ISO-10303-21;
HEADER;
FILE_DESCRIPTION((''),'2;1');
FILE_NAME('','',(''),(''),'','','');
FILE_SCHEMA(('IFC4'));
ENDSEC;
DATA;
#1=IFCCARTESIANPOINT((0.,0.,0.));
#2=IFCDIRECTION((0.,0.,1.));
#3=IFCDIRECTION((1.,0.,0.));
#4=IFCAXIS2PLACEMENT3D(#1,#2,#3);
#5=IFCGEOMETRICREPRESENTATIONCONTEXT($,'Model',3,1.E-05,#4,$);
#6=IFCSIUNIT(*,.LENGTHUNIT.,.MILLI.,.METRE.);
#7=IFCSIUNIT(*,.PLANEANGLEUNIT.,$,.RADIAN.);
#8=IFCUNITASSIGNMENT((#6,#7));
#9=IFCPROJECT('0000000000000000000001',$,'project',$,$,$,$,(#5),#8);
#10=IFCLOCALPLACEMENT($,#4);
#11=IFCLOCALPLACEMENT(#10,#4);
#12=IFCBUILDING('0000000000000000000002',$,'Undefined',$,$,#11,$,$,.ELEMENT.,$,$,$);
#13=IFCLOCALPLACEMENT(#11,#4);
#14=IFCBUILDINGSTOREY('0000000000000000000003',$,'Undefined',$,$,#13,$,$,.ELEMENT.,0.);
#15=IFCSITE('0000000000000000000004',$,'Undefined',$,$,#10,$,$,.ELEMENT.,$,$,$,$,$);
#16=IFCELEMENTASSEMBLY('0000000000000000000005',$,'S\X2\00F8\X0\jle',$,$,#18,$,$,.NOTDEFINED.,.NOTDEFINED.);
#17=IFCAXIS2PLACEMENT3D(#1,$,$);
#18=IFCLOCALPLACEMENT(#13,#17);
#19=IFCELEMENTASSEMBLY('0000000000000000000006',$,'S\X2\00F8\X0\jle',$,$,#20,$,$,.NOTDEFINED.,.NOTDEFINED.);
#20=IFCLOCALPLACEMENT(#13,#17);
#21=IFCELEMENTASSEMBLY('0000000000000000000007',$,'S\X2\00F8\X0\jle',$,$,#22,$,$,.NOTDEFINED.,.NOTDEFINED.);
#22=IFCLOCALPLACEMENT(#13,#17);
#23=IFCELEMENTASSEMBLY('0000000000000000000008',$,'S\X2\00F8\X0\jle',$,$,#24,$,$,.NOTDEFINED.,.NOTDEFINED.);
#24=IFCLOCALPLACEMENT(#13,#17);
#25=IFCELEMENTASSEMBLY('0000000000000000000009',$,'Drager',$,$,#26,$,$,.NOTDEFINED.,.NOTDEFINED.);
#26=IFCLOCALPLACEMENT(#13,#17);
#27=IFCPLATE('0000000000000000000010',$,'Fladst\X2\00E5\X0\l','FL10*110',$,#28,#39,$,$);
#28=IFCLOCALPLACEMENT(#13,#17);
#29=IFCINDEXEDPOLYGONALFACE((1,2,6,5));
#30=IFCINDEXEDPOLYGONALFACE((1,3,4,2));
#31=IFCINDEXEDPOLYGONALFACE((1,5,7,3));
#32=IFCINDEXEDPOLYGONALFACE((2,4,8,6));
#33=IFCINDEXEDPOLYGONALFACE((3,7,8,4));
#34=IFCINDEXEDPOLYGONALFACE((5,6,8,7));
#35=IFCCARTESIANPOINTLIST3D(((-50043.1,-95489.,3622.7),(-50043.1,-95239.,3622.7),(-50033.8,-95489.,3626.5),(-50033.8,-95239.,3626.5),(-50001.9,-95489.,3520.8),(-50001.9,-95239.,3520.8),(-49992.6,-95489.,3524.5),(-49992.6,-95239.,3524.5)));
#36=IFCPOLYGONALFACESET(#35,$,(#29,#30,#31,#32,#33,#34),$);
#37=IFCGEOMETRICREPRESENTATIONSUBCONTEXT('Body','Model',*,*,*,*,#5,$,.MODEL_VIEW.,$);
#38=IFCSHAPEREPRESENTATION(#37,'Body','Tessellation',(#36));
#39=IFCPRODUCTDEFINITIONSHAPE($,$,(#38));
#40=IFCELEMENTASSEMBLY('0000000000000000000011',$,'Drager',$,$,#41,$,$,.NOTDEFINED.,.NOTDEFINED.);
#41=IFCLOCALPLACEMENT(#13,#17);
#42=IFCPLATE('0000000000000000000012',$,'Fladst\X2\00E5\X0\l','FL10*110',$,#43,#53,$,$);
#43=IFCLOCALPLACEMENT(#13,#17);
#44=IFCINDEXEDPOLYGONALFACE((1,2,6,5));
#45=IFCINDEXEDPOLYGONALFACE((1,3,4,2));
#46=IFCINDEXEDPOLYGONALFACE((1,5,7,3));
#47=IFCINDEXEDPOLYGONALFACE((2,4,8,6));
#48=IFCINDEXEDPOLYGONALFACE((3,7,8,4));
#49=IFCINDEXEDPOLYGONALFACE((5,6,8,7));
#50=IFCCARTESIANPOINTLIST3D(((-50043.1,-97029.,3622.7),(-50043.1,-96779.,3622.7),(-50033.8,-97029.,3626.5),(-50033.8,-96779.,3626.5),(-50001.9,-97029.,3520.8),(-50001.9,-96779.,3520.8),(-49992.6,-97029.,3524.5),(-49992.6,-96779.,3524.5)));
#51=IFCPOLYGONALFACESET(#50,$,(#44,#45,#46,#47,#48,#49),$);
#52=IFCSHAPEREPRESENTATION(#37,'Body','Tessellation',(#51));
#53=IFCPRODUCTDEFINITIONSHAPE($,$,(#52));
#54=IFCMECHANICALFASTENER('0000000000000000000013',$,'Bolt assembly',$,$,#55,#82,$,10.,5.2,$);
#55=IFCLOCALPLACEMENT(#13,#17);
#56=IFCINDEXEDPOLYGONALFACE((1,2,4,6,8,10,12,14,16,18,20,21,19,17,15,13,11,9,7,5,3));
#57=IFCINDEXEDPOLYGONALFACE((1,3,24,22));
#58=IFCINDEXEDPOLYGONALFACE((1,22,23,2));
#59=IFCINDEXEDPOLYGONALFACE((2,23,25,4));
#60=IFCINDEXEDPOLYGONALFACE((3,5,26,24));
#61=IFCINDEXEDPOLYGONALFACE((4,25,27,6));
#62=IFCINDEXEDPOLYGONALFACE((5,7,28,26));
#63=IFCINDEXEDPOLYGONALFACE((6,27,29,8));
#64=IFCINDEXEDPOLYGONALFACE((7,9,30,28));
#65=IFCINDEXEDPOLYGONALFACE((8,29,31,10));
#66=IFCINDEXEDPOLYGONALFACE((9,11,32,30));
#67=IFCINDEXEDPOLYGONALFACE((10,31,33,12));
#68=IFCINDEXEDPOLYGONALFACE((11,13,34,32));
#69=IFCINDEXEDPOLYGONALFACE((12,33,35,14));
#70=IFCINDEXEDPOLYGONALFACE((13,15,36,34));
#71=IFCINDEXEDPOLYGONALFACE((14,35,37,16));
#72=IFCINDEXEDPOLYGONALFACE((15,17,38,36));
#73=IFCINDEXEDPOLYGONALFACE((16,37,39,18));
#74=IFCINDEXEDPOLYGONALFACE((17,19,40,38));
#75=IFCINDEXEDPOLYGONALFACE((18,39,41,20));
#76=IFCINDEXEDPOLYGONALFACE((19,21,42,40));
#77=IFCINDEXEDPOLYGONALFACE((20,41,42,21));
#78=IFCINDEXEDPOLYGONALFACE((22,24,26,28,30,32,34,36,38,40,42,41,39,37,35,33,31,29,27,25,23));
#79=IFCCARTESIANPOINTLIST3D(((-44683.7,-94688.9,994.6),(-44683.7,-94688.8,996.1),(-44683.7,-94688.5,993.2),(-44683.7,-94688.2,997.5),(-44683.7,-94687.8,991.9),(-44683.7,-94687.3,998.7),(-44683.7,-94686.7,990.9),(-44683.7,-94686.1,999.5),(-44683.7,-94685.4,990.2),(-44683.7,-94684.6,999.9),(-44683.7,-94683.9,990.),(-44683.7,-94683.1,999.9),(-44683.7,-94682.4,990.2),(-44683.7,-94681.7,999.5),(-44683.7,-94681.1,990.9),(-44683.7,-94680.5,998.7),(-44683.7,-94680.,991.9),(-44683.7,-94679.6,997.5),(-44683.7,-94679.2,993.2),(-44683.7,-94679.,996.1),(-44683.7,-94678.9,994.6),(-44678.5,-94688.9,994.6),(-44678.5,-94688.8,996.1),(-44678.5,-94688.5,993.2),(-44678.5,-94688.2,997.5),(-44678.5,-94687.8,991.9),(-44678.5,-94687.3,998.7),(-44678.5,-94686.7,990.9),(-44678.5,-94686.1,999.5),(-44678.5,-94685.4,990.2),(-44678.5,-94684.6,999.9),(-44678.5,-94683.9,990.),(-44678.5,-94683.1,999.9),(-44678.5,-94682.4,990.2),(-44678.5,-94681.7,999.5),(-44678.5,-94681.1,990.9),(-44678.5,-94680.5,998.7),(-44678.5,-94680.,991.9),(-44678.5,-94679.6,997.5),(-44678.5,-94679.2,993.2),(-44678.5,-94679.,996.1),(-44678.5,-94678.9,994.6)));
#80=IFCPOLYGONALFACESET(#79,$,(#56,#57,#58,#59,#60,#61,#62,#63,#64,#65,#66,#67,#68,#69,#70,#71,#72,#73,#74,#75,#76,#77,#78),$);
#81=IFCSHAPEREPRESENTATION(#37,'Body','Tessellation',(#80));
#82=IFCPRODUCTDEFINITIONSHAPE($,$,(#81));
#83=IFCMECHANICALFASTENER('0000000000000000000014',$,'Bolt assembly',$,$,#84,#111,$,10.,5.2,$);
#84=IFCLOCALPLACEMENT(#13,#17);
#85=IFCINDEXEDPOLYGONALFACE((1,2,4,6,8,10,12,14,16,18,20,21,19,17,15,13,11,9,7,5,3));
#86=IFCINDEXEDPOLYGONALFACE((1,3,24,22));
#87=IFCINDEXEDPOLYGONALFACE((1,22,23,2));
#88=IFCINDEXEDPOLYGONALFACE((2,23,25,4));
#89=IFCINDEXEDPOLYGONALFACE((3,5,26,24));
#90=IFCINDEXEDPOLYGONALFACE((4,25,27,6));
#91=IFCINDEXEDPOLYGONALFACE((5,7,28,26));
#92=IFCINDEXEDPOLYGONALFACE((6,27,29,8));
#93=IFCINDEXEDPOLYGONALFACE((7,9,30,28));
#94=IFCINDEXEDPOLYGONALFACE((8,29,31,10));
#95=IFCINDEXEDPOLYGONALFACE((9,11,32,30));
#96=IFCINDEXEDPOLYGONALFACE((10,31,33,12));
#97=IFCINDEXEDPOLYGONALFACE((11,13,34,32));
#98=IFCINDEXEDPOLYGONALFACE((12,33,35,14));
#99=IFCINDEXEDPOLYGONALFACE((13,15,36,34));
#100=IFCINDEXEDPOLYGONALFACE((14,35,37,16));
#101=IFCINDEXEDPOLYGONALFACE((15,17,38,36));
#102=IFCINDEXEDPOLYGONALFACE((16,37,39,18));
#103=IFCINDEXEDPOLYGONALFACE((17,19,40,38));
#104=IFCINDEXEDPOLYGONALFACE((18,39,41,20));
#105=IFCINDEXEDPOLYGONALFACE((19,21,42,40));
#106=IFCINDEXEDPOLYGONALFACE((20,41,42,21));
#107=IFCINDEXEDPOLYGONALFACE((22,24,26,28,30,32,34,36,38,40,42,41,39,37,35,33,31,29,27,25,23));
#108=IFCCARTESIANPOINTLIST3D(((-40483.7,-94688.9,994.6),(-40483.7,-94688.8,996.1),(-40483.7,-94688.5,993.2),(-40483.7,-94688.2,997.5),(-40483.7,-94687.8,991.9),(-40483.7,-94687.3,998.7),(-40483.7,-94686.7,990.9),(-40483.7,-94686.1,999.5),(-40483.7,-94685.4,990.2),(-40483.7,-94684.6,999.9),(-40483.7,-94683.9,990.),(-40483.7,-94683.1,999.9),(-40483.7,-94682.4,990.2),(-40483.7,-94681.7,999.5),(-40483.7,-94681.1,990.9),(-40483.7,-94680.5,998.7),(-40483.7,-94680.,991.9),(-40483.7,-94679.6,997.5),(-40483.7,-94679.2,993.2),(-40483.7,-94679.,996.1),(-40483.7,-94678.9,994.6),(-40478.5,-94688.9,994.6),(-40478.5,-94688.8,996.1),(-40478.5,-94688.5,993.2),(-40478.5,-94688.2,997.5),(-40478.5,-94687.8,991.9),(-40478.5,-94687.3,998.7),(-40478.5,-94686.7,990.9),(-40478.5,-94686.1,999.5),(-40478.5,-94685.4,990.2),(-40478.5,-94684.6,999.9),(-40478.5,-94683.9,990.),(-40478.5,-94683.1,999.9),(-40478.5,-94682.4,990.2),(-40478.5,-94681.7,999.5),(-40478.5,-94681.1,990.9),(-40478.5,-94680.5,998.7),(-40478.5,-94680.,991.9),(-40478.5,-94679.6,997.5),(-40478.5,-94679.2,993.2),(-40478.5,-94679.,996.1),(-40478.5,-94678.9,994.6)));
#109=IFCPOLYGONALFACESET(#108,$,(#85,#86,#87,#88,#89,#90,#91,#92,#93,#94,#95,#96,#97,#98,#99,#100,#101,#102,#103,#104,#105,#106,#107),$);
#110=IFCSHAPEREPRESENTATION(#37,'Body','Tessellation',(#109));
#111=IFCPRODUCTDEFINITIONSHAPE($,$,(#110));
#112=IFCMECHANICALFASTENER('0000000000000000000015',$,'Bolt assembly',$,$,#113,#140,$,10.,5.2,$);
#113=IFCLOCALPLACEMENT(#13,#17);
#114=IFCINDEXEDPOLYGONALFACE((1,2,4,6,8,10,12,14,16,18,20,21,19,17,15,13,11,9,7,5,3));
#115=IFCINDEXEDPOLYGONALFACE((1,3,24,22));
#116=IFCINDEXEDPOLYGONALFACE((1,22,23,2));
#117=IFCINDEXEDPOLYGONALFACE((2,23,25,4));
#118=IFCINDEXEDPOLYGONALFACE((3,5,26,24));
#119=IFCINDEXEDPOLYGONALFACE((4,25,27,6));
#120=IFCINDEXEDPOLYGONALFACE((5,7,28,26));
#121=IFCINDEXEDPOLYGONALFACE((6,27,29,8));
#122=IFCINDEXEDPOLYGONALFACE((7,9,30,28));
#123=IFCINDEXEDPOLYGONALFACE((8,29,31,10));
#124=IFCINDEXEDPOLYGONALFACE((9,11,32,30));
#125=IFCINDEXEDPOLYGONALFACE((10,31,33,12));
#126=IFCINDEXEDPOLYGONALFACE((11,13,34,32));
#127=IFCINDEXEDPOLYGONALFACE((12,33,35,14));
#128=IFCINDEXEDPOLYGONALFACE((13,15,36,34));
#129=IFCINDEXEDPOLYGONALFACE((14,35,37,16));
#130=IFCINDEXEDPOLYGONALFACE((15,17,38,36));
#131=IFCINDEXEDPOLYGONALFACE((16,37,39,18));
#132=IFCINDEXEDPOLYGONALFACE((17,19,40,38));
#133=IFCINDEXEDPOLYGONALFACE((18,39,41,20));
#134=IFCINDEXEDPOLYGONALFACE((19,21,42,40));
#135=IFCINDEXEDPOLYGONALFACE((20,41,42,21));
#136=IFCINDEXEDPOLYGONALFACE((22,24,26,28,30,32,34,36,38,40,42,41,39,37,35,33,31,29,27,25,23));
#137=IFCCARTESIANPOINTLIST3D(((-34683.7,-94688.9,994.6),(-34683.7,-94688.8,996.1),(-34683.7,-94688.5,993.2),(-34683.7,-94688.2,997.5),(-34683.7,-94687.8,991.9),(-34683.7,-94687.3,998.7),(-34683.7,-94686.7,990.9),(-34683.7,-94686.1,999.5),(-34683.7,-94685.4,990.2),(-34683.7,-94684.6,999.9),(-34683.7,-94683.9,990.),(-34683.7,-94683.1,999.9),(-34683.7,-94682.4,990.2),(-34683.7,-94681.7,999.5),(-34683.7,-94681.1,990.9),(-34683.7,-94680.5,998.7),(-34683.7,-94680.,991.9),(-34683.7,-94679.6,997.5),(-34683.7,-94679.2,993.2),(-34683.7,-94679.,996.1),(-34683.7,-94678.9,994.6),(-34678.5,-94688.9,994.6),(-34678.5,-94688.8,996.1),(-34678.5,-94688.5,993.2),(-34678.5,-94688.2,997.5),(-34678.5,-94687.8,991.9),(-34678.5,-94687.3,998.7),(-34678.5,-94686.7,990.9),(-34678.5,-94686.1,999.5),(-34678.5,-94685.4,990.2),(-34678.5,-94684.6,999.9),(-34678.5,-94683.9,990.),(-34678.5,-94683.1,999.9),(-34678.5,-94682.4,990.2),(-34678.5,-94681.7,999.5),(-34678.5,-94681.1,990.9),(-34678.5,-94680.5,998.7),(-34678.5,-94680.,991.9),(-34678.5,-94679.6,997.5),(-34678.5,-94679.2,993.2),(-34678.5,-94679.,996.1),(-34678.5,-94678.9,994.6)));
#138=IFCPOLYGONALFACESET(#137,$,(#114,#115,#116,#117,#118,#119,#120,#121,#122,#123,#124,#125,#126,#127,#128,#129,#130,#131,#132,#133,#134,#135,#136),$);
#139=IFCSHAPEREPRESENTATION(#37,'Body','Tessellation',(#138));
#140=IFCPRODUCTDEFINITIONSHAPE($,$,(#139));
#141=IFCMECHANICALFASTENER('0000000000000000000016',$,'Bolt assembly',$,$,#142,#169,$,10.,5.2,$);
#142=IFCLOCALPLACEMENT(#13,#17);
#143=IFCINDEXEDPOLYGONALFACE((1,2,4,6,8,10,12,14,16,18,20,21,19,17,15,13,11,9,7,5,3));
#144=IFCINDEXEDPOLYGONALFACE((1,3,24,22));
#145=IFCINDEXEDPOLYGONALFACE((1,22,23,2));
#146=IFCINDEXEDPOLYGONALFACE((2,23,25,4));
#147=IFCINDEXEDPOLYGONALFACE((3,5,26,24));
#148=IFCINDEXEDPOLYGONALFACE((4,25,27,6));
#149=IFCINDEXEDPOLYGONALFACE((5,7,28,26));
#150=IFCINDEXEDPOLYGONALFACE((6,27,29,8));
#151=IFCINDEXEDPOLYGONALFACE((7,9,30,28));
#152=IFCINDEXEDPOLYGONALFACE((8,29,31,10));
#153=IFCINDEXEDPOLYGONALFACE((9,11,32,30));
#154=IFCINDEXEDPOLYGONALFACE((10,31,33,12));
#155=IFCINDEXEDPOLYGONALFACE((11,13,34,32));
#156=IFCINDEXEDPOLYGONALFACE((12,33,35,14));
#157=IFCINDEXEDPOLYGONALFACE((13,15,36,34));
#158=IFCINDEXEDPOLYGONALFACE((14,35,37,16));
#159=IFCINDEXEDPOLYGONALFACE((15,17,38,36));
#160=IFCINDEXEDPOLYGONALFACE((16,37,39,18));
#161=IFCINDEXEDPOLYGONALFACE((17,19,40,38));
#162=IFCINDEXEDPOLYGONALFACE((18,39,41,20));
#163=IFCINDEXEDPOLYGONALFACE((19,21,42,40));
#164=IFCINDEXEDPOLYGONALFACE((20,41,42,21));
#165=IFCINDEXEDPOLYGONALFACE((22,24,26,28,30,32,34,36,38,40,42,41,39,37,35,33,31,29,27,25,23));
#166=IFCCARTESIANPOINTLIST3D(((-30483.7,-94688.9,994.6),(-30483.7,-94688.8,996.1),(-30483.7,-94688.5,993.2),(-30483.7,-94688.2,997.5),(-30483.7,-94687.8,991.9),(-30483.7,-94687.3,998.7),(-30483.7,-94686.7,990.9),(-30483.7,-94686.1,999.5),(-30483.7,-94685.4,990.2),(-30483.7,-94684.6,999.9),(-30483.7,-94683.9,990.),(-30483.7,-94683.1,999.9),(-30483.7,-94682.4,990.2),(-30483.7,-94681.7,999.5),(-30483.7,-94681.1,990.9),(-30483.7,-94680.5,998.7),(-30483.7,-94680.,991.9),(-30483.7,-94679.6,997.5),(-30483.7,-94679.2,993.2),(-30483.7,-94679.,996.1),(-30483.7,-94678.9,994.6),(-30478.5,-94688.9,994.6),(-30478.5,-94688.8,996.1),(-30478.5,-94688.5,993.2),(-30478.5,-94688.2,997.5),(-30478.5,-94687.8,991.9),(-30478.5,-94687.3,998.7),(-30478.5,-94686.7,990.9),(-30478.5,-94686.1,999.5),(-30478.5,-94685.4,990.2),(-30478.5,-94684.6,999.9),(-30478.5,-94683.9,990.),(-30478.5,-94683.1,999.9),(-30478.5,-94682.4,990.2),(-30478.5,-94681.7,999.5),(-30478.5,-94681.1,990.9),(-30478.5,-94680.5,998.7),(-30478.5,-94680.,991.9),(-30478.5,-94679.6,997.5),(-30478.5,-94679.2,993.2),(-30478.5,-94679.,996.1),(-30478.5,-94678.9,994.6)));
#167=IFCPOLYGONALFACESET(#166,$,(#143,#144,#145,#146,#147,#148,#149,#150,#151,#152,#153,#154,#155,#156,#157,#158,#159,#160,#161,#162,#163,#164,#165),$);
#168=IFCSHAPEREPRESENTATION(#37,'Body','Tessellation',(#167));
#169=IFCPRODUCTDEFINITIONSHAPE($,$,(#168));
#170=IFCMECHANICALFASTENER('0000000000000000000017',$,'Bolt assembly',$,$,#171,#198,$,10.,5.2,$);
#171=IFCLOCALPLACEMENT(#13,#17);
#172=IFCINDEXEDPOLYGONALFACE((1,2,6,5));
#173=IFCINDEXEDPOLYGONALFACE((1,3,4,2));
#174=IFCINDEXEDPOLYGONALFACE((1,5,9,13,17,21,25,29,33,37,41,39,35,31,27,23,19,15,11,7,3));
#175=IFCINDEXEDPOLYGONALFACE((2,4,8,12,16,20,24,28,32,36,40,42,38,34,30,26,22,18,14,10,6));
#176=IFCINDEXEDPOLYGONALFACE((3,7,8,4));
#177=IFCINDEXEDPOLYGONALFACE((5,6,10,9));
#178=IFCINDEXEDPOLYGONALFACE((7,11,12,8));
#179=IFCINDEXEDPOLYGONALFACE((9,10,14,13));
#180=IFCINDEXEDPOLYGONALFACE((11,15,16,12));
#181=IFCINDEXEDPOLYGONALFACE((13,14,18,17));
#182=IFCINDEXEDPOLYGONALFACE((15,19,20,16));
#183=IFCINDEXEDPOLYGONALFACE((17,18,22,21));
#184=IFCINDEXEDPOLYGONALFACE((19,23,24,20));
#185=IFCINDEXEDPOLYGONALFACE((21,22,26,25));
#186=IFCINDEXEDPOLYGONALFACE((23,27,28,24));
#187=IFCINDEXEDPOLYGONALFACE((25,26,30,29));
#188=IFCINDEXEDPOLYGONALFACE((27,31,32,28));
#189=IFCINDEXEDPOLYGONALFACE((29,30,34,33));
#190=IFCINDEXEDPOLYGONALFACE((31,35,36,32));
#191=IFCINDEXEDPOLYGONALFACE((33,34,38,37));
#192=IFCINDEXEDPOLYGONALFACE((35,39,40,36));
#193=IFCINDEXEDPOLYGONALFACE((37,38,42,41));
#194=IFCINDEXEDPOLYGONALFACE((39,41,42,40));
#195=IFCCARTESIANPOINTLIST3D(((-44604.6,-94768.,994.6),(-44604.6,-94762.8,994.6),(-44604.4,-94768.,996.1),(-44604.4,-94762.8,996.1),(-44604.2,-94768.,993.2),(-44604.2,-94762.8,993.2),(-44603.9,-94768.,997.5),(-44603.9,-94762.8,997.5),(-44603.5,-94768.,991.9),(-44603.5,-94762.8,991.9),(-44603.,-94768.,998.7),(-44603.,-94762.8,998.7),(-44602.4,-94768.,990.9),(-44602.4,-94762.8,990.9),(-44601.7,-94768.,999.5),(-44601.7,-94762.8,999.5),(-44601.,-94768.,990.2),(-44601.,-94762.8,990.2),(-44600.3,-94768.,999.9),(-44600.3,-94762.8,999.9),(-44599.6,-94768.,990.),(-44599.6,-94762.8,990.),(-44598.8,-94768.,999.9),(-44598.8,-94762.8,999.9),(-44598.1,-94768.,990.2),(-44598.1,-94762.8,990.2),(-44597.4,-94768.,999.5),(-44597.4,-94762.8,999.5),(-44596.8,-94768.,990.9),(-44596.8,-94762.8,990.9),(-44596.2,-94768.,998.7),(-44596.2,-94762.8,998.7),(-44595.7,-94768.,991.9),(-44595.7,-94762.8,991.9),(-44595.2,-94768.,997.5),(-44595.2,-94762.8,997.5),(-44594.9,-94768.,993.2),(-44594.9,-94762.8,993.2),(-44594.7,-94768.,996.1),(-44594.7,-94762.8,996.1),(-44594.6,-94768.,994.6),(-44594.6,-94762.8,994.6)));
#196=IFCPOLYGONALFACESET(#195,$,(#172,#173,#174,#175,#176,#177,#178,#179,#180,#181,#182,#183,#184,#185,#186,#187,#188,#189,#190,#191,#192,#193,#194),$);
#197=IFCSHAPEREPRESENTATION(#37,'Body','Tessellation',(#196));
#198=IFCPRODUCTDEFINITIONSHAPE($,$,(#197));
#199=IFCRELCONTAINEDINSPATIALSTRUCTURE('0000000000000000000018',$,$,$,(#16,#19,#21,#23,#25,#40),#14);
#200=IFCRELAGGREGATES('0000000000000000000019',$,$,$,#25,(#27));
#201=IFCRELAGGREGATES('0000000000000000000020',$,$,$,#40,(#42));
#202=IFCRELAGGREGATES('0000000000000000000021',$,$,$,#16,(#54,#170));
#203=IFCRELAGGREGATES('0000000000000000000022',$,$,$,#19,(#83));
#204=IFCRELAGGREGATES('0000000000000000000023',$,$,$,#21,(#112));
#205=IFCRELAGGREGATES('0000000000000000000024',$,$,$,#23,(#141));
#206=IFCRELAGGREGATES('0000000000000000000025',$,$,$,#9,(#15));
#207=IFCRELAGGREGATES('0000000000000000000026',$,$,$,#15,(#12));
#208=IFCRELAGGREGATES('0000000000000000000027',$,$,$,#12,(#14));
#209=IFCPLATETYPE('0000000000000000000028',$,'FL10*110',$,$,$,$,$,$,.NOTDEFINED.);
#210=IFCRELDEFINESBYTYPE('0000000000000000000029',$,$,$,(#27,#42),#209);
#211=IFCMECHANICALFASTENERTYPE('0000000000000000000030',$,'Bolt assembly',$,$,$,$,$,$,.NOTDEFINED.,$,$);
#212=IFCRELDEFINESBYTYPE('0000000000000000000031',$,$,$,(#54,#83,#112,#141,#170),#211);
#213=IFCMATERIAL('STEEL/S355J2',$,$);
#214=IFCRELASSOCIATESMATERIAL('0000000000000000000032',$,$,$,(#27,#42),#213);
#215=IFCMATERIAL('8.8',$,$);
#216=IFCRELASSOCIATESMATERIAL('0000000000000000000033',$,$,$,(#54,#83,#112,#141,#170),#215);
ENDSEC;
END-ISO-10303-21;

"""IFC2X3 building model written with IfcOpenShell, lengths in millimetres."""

from ifc_helpers import new_model, si_unit, frame, origin_with_axes, origin_2d_with_axis, place, context, subcontext, project, spatial, polyline, circle, outline, extrude, source, transform, mapped, material, type_object, element, aggregate, save


model = new_model("IFC2X3")

# Units and contexts
model_context = context("Model", 3, precision=1e-05, world=origin_with_axes())
body_context = subcontext(model_context, "Body", "Model", "MODEL_VIEW")
ifc_project = project(units=[si_unit("LENGTHUNIT", "METRE", prefix="MILLI"), si_unit("PLANEANGLEUNIT", "RADIAN")], contexts=[model_context])

# Site, building, storey
site_placement = place(None, origin_with_axes())
site = spatial("IfcSite", under=ifc_project, at=site_placement, Name="Undefined", CompositionType="ELEMENT")
building_placement = place(site_placement, origin_with_axes())
building = spatial("IfcBuilding", under=site, at=building_placement, Name="Undefined", CompositionType="ELEMENT")
storey_placement = place(building_placement, origin_with_axes())
storey = spatial("IfcBuildingStorey", under=building, at=storey_placement, Name="Undefined", CompositionType="ELEMENT", Elevation=0.0)

# Element assemblies
assembly_1_placement = place(storey_placement, origin_with_axes())
assembly_1 = element("IfcElementAssembly", 1, at=assembly_1_placement, inside=storey, Name="Søjle", AssemblyPlace="NOTDEFINED", PredefinedType="NOTDEFINED")
ifc_material_1 = material(Name="STEEL/S355J2")
assembly_2_placement = place(storey_placement, origin_with_axes())
assembly_2 = element("IfcElementAssembly", 2, at=assembly_2_placement, inside=storey, Name="Søjle", AssemblyPlace="NOTDEFINED", PredefinedType="NOTDEFINED")
assembly_3_placement = place(storey_placement, origin_with_axes())
assembly_3 = element("IfcElementAssembly", 3, at=assembly_3_placement, inside=storey, Name="Søjle", AssemblyPlace="NOTDEFINED", PredefinedType="NOTDEFINED")
assembly_4_placement = place(storey_placement, origin_with_axes())
assembly_4 = element("IfcElementAssembly", 4, at=assembly_4_placement, inside=storey, Name="Søjle", AssemblyPlace="NOTDEFINED", PredefinedType="NOTDEFINED")

# Element assembly
assembly_5_placement = place(storey_placement, origin_with_axes())
assembly_5 = element("IfcElementAssembly", 5, at=assembly_5_placement, inside=storey, Name="Drager", AssemblyPlace="NOTDEFINED", PredefinedType="NOTDEFINED")

# Plate
plate_type_1 = type_object("IfcPlateType", Name="FL10*110", PredefinedType="NOTDEFINED")
plate_1_placement = place(assembly_5_placement, frame((-50017.8, -95239.0, 3573.6), z_axis=(-0.927184, 0.0, -0.374606), x_axis=(0.0, -1.0, 0.0)))
plate_1 = element("IfcPlate", 6, at=plate_1_placement, type_object=plate_type_1, material=ifc_material_1, Name="Fladstål", Description="FL10*110", context=body_context, shape_type="SweptSolid", body=[
    extrude(outline(polyline([(0.0, -55.0), (0.0, 55.0), (250.0, 55.0), (250.0, -55.0), (0.0, -55.0)])), frame((0.0, 0.0, -5.0), z_axis=(0.0, 0.0, 1.0), x_axis=(1.0, 0.0, 0.0)), (0.0, 0.0, 1.0), 10.0),
])
aggregate(assembly_5, [plate_1])

# Element assembly, plate
assembly_6_placement = place(storey_placement, origin_with_axes())
assembly_6 = element("IfcElementAssembly", 7, at=assembly_6_placement, inside=storey, Name="Drager", AssemblyPlace="NOTDEFINED", PredefinedType="NOTDEFINED")
plate_2_placement = place(assembly_6_placement, frame((-50017.9, -97029.0, 3573.6), z_axis=(-0.927184, 0.0, -0.374606), x_axis=(0.0, 1.0, 0.0)))
plate_2 = element("IfcPlate", 8, at=plate_2_placement, type_object=plate_type_1, material=ifc_material_1, Name="Fladstål", Description="FL10*110", context=body_context, shape_type="SweptSolid", body=[
    extrude(outline(polyline([(0.0, -55.0), (0.0, 55.0), (250.0, 55.0), (250.0, -55.0), (0.0, -55.0)])), frame((0.0, 0.0, -5.0), z_axis=(0.0, 0.0, 1.0), x_axis=(1.0, 0.0, 0.0)), (0.0, 0.0, 1.0), 10.0),
])
aggregate(assembly_6, [plate_2])

# Mechanical fasteners
ifc_material_2 = material(Name="8.8")
mechanical_fastener_type = type_object("IfcMechanicalFastenerType", Name="Bolt assembly")
shared_shape_1 = source(origin_with_axes(), body_context, "Body", "SweptSolid", [
    extrude(circle(Radius=5.0, at=origin_2d_with_axis()), frame((0.0, 0.0, 0.0), z_axis=(0.0, 1.0, 0.0), x_axis=(1.0, 0.0, 0.0)), (0.0, 0.0, 1.0), 5.3),
])
mechanical_fastener_1_placement = place(assembly_1_placement, frame((-44683.7, -94683.9, 995.0), z_axis=(0.0, -1.0, 0.0), x_axis=(0.0, 0.0, -1.0)))
mechanical_fastener_1 = element("IfcMechanicalFastener", 9, at=mechanical_fastener_1_placement, type_object=mechanical_fastener_type, material=ifc_material_2, Name="Bolt assembly", NominalDiameter=10.0, NominalLength=5.2, context=body_context, shape_type="MappedRepresentation", body=[
    mapped(shared_shape_1, transform((0.0, 0.0, 0.0))),
])
mechanical_fastener_2_placement = place(assembly_2_placement, frame((-40483.7, -94683.9, 995.0), z_axis=(0.0, -1.0, 0.0), x_axis=(0.0, 0.0, -1.0)))
mechanical_fastener_2 = element("IfcMechanicalFastener", 10, at=mechanical_fastener_2_placement, type_object=mechanical_fastener_type, material=ifc_material_2, Name="Bolt assembly", NominalDiameter=10.0, NominalLength=5.2, context=body_context, shape_type="MappedRepresentation", body=[
    mapped(shared_shape_1, transform((0.0, 0.0, 0.0))),
])
mechanical_fastener_3_placement = place(assembly_3_placement, frame((-34683.7, -94683.9, 995.0), z_axis=(0.0, -1.0, 0.0), x_axis=(0.0, 0.0, -1.0)))
mechanical_fastener_3 = element("IfcMechanicalFastener", 11, at=mechanical_fastener_3_placement, type_object=mechanical_fastener_type, material=ifc_material_2, Name="Bolt assembly", NominalDiameter=10.0, NominalLength=5.2, context=body_context, shape_type="MappedRepresentation", body=[
    mapped(shared_shape_1, transform((0.0, 0.0, 0.0))),
])
mechanical_fastener_4_placement = place(assembly_4_placement, frame((-30483.7, -94683.9, 995.0), z_axis=(0.0, -1.0, 0.0), x_axis=(0.0, 0.0, -1.0)))
mechanical_fastener_4 = element("IfcMechanicalFastener", 12, at=mechanical_fastener_4_placement, type_object=mechanical_fastener_type, material=ifc_material_2, Name="Bolt assembly", NominalDiameter=10.0, NominalLength=5.2, context=body_context, shape_type="MappedRepresentation", body=[
    mapped(shared_shape_1, transform((0.0, 0.0, 0.0))),
])
shared_shape_2 = source(origin_with_axes(), body_context, "Body", "SweptSolid", [
    extrude(circle(Radius=5.0, at=origin_2d_with_axis()), frame((0.0, 0.0, 0.0), z_axis=(0.0, 1.0, 0.0), x_axis=(1.0, 0.0, 0.0)), (0.0, 0.0, 1.0), 5.3),
])
mechanical_fastener_5_placement = place(assembly_1_placement, frame((-44599.6, -94768.0, 995.0), z_axis=(1.0, 0.0, 0.0), x_axis=(0.0, 0.0, -1.0)))
mechanical_fastener_5 = element("IfcMechanicalFastener", 13, at=mechanical_fastener_5_placement, type_object=mechanical_fastener_type, material=ifc_material_2, Name="Bolt assembly", NominalDiameter=10.0, NominalLength=5.2, context=body_context, shape_type="MappedRepresentation", body=[
    mapped(shared_shape_2, transform((0.0, 0.0, 0.0))),
])
aggregate(assembly_1, [mechanical_fastener_1, mechanical_fastener_5])
aggregate(assembly_2, [mechanical_fastener_2])
aggregate(assembly_3, [mechanical_fastener_3])
aggregate(assembly_4, [mechanical_fastener_4])

save(model, "model.ifc")
